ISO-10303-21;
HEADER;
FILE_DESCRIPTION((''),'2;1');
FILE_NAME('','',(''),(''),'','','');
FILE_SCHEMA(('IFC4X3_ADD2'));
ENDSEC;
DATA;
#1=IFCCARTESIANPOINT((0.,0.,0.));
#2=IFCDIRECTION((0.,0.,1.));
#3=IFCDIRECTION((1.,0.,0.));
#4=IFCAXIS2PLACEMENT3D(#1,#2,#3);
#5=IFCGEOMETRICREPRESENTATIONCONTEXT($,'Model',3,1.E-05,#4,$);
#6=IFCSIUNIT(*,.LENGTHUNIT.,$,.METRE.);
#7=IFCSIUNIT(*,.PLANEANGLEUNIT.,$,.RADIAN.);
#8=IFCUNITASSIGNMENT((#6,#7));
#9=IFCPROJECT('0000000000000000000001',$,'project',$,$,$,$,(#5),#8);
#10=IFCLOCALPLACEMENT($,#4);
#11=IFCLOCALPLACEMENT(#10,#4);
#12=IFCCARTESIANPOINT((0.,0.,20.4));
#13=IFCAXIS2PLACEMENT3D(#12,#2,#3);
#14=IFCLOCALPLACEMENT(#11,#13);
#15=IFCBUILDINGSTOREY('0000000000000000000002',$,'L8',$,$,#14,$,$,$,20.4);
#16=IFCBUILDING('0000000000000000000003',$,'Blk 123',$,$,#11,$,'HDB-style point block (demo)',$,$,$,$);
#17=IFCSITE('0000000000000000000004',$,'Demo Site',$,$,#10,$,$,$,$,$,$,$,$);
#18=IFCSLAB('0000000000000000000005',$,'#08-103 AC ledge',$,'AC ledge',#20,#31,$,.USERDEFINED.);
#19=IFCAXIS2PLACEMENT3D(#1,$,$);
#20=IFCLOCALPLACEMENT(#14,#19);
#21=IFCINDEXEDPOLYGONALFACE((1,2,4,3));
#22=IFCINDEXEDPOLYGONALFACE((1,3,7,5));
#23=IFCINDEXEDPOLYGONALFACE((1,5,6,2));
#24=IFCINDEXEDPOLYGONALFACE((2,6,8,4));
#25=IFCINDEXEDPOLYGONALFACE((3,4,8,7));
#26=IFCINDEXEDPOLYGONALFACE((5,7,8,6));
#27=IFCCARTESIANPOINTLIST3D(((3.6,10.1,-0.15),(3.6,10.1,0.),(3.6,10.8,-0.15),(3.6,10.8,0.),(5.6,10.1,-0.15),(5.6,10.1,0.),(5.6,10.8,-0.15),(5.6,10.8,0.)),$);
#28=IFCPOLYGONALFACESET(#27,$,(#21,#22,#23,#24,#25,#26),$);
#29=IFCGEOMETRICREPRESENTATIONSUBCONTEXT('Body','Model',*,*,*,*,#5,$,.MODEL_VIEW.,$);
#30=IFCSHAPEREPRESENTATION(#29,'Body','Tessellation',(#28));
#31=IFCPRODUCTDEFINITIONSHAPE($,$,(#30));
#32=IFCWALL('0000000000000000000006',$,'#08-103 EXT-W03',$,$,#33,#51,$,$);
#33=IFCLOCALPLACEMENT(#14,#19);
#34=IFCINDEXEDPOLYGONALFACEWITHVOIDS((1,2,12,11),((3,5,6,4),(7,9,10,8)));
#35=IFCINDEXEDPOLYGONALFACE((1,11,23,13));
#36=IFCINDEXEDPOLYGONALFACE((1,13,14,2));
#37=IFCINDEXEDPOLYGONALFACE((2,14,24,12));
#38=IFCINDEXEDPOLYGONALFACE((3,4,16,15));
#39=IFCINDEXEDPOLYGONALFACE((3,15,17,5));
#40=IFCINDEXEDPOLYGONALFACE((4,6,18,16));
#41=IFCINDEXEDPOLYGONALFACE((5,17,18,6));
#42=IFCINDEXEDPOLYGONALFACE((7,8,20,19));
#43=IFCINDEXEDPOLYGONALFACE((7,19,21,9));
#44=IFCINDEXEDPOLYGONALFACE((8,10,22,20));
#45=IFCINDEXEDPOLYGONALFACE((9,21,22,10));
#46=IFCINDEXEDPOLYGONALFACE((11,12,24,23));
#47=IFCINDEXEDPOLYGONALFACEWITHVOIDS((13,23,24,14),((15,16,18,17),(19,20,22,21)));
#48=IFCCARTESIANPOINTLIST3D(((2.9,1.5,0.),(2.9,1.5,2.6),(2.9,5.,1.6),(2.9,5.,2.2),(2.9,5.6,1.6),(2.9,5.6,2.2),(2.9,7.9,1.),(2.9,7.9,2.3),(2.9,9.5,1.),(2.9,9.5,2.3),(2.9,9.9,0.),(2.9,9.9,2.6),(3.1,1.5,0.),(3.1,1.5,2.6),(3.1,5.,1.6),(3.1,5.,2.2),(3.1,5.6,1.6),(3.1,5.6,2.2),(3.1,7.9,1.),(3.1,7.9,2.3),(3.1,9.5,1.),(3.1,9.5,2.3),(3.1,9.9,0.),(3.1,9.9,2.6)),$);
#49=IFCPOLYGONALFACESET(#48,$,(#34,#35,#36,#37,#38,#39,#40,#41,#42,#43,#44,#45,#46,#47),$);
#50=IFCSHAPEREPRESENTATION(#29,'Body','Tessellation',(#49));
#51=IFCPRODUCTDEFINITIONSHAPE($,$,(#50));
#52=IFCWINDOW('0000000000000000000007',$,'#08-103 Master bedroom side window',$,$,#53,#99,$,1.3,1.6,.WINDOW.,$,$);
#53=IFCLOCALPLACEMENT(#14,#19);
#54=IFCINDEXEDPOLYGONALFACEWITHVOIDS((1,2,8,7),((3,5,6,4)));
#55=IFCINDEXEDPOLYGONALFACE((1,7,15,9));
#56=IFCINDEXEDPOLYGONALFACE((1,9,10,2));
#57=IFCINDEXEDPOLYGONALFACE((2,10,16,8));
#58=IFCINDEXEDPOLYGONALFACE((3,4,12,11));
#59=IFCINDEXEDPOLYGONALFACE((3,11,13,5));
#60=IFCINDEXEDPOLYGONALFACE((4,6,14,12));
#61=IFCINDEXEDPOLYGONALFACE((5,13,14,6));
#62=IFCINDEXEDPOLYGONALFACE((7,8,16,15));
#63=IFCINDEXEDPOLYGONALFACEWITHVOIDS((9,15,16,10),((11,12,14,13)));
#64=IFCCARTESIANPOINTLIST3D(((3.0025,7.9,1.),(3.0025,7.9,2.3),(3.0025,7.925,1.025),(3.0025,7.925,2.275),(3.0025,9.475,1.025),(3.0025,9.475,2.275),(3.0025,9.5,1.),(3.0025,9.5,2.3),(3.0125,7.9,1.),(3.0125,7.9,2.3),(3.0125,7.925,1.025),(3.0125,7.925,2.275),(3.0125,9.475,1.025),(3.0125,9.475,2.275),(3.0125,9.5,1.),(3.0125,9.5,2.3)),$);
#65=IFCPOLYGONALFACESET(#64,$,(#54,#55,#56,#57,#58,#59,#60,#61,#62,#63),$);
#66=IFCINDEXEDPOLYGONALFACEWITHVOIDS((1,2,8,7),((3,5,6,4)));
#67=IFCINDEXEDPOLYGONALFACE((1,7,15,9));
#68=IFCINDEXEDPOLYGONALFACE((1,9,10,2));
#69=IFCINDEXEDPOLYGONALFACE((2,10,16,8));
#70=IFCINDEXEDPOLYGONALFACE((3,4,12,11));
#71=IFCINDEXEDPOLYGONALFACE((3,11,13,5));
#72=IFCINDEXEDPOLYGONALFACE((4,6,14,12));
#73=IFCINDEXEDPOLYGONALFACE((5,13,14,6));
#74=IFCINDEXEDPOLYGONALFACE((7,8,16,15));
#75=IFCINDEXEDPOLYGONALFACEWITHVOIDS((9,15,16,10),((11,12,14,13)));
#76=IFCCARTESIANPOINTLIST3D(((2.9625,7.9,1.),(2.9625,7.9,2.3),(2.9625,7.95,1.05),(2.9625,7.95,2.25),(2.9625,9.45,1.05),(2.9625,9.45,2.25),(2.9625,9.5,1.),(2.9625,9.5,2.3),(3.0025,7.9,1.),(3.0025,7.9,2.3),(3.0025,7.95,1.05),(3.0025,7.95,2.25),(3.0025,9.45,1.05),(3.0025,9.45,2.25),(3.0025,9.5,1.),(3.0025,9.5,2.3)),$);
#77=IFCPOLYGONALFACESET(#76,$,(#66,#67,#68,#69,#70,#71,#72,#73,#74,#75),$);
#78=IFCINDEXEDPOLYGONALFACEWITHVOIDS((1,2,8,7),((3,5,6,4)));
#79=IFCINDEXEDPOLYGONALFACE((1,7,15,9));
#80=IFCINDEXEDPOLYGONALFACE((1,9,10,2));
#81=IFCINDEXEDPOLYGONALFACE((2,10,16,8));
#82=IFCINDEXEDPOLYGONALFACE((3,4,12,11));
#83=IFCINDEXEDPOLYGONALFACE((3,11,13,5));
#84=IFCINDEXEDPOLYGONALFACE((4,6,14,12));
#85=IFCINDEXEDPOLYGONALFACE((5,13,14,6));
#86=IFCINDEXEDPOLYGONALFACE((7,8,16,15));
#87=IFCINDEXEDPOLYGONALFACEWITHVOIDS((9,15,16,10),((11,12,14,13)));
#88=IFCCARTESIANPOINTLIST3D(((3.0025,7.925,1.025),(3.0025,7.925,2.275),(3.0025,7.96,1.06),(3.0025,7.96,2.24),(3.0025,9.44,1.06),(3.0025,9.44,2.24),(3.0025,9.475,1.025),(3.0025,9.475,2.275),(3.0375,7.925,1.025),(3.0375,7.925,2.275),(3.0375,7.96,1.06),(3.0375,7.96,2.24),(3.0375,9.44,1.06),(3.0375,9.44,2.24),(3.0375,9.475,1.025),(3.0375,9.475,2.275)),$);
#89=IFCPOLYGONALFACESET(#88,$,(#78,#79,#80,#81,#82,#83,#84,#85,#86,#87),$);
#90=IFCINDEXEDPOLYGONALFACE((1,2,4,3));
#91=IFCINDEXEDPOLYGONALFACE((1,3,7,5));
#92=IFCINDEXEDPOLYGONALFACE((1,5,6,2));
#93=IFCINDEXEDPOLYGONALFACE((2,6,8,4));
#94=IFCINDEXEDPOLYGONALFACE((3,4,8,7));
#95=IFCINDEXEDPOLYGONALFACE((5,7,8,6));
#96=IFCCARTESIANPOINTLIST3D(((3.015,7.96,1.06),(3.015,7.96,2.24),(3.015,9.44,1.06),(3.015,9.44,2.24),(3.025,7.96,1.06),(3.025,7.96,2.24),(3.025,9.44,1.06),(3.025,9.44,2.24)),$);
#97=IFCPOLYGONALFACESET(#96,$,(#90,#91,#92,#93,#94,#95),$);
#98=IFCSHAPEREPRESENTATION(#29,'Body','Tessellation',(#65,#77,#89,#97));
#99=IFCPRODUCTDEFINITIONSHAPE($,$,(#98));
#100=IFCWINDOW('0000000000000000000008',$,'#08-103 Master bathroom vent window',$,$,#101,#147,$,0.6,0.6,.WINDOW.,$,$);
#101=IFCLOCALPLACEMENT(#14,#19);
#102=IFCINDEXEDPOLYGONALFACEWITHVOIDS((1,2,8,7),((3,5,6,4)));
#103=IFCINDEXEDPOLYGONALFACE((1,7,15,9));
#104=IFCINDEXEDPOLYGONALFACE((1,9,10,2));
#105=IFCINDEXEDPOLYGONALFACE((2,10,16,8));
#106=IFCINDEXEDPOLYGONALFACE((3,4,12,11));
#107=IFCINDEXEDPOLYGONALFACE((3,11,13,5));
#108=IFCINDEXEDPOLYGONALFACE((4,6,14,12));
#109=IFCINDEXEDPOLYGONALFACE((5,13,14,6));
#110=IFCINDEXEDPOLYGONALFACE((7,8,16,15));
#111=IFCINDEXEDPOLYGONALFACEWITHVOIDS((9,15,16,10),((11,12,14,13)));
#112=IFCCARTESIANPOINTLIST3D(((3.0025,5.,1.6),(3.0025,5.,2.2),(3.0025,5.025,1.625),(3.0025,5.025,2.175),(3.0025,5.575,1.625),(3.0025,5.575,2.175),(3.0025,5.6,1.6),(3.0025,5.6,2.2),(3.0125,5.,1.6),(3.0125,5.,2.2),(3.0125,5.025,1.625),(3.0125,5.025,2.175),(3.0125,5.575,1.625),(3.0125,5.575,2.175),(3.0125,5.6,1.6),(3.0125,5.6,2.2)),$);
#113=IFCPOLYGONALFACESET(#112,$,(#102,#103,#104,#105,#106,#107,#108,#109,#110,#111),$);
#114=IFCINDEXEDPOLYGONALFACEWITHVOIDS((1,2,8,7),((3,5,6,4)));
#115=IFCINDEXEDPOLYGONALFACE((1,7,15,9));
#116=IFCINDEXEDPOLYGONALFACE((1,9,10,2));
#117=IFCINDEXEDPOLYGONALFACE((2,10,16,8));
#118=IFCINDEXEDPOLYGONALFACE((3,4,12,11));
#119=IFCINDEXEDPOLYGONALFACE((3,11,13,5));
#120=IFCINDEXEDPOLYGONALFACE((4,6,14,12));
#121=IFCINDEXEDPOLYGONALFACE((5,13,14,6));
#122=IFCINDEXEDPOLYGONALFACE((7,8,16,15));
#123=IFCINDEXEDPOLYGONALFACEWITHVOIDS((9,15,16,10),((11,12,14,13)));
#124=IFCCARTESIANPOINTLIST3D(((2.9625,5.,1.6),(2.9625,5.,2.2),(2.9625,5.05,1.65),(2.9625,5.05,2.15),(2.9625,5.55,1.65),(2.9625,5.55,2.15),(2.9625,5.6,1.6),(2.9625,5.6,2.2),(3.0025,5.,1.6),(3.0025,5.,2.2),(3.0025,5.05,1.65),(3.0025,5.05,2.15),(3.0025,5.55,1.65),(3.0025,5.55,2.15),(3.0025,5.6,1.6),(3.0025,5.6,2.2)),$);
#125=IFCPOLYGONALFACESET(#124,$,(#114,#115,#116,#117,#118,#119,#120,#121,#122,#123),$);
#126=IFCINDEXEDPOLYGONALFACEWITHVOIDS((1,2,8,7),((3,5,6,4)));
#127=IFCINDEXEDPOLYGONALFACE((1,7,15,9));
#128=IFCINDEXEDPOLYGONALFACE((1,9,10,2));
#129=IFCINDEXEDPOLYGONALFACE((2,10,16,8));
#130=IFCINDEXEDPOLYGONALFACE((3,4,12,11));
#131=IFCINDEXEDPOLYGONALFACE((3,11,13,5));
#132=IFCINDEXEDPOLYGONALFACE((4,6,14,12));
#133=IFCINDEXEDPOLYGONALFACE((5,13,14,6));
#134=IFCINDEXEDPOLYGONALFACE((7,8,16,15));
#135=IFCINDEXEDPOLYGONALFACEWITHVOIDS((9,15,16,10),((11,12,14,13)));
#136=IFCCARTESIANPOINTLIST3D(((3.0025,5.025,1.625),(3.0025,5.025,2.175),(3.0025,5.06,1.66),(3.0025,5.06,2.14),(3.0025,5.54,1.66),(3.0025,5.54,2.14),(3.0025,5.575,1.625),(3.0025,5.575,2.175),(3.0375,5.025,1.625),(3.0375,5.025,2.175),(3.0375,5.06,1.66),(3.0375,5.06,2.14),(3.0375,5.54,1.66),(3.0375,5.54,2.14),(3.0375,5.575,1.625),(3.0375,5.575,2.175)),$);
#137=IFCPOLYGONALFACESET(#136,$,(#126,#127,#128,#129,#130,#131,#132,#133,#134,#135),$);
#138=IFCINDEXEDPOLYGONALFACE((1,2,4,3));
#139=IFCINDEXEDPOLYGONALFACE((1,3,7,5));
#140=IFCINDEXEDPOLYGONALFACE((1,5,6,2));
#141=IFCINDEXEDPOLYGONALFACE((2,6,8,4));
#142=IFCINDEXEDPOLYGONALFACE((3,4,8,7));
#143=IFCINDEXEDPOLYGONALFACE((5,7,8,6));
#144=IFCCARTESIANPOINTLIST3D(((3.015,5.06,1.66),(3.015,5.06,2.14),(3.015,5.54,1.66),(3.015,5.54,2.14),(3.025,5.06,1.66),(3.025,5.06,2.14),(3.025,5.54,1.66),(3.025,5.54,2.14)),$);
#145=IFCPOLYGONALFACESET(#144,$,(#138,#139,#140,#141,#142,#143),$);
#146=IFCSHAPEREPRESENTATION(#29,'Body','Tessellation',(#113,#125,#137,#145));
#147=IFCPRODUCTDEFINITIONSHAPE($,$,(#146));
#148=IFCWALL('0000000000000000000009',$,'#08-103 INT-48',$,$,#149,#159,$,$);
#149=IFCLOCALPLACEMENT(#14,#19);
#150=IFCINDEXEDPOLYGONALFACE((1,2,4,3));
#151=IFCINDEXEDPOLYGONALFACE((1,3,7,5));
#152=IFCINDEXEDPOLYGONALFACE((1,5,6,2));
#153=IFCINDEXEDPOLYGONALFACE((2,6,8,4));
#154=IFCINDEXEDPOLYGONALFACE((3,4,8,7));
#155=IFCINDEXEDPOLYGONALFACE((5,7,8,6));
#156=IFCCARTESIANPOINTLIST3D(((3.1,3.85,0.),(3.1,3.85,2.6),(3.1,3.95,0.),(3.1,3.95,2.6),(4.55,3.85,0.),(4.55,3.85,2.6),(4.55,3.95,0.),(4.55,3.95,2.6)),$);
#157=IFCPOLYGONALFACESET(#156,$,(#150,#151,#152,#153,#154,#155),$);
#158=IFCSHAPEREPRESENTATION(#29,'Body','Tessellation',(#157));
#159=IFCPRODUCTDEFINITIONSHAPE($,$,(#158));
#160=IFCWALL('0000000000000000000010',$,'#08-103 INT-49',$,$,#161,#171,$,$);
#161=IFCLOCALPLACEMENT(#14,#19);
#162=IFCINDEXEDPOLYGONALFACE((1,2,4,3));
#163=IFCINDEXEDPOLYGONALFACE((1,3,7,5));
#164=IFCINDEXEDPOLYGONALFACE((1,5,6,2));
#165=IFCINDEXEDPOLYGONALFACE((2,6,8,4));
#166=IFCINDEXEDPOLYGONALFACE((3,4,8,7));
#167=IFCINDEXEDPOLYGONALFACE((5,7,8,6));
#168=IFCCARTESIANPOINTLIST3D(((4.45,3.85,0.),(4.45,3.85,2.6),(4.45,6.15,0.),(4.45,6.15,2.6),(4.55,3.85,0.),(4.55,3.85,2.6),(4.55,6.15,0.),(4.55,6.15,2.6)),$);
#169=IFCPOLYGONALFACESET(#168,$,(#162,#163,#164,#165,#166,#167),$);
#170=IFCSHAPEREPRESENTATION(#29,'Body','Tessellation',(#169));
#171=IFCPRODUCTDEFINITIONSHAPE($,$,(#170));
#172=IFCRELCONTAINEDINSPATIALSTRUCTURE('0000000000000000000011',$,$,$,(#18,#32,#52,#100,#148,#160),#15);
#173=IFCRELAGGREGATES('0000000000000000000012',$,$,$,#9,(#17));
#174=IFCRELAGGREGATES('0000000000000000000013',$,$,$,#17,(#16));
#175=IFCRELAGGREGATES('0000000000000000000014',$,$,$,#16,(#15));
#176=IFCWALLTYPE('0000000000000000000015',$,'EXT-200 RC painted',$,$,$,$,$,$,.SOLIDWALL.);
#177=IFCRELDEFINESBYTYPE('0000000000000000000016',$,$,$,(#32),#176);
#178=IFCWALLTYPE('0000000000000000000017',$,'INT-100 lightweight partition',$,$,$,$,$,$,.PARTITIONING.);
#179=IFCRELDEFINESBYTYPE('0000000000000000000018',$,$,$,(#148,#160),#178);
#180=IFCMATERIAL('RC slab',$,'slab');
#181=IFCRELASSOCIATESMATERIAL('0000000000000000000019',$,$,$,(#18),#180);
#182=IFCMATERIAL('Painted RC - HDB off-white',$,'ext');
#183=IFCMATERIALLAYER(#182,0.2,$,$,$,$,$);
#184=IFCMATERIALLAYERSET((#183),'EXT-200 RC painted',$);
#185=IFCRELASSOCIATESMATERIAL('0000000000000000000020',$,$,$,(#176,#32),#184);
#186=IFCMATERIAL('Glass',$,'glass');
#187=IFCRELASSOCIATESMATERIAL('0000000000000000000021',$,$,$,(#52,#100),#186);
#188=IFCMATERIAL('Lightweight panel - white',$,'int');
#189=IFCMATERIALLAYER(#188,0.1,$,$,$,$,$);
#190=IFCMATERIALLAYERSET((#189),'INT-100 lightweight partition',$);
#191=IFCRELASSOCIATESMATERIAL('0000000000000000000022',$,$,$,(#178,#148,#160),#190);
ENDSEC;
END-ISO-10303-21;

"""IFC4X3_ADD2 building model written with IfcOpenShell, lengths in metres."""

from ifc_helpers import new_model, si_unit, frame, origin, origin_with_axes, place, context, subcontext, project, spatial, polyline, line, indexed_curve, outline, extrude, material, layer, layer_set, layer_usage, type_object, element, fill, save


model = new_model("IFC4X3_ADD2")

# Units and contexts
model_context = context("Model", 3, precision=1e-05, world=origin_with_axes())
body_context = subcontext(model_context, "Body", "Model", "MODEL_VIEW")
ifc_project = project(units=[si_unit("LENGTHUNIT", "METRE"), si_unit("PLANEANGLEUNIT", "RADIAN")], contexts=[model_context])

# Site, building, storey
site_placement = place(None, origin_with_axes())
site = spatial("IfcSite", under=ifc_project, at=site_placement, Name="Demo Site")
building_placement = place(site_placement, origin_with_axes())
building = spatial("IfcBuilding", under=site, at=building_placement, Name="Blk 123", LongName="HDB-style point block (demo)")
storey_placement = place(building_placement, frame((0.0, 0.0, 20.4), z_axis=(0.0, 0.0, 1.0), x_axis=(1.0, 0.0, 0.0)))
storey = spatial("IfcBuildingStorey", under=building, at=storey_placement, Name="L8", Elevation=20.4)

# Slab
ifc_material_1 = material(Name="RC slab", Category="slab")
slab_placement = place(storey_placement, frame((4.6, 10.45, -0.15), z_axis=(0.0, 0.0, 1.0), x_axis=(1.0, 0.0, 0.0)))
element("IfcSlab", 1, at=slab_placement, inside=storey, material=ifc_material_1, Name="#08-103 AC ledge", ObjectType="AC ledge", PredefinedType="USERDEFINED", context=body_context, shape_type="SweptSolid", body=[
    extrude(outline(polyline([(1.0, -0.35), (1.0, 0.35), (-1.0, 0.35), (-1.0, -0.35), (1.0, -0.35)])), origin(), (0.0, 0.0, 1.0), 0.15),
])

# Wall, openings, windows
ifc_material_2 = material(Name="Painted RC - HDB off-white", Category="ext")
ifc_layer_1 = layer(ifc_material_2, 0.2)
ifc_layer_set_1 = layer_set([ifc_layer_1], Name="EXT-200 RC painted")
ifc_layer_usage_1 = layer_usage(ifc_layer_set_1, "AXIS2", "POSITIVE", 0.0)
wall_type_1 = type_object("IfcWallType", Name="EXT-200 RC painted", PredefinedType="SOLIDWALL", material=ifc_layer_set_1)
wall_1_placement = place(storey_placement, frame((2.9, 9.9, 0.0), z_axis=(0.0, 0.0, 1.0), x_axis=(0.0, -1.0, 0.0)))
wall_1 = element("IfcWall", 2, at=wall_1_placement, inside=storey, type_object=wall_type_1, material=ifc_layer_usage_1, Name="#08-103 EXT-W03", context=body_context, shape_type="SweptSolid", body=[
    extrude(outline(indexed_curve([(0.0, 0.0), (0.0, 0.2), (8.4, 0.2), (8.4, 0.0), (0.0, 0.0)], self_intersect=False)), origin_with_axes(), (0.0, 0.0, 1.0), 2.6),
])
opening_1_placement = place(wall_1_placement, frame((0.4, -0.1, 1.0), z_axis=(0.0, 0.0, 1.0), x_axis=(1.0, 0.0, 0.0)))
opening_1 = element("IfcOpeningElement", 3, at=opening_1_placement, cuts=wall_1, context=body_context, shape_type="SweptSolid", body=[
    extrude(outline(indexed_curve([(0.0, 0.0), (0.0, 0.4), (1.6, 0.4), (1.6, 0.0), (0.0, 0.0)], self_intersect=False)), origin_with_axes(), (0.0, 0.0, 1.0), 1.3),
])
opening_2_placement = place(wall_1_placement, frame((4.3, -0.1, 1.6), z_axis=(0.0, 0.0, 1.0), x_axis=(1.0, 0.0, 0.0)))
opening_2 = element("IfcOpeningElement", 4, at=opening_2_placement, cuts=wall_1, context=body_context, shape_type="SweptSolid", body=[
    extrude(outline(indexed_curve([(0.0, 0.0), (0.0, 0.4), (0.6, 0.4), (0.6, 0.0), (0.0, 0.0)], self_intersect=False)), origin_with_axes(), (0.0, 0.0, 1.0), 0.6),
])
ifc_material_3 = material(Name="Glass", Category="glass")
window_1_placement = place(opening_1_placement, frame((0.0, 0.1125, 0.0), z_axis=(0.0, 0.0, 1.0), x_axis=(1.0, 0.0, 0.0)))
window_1 = element("IfcWindow", 5, at=window_1_placement, inside=storey, material=ifc_material_3, Name="#08-103 Master bedroom side window", OverallHeight=1.3, OverallWidth=1.6, PredefinedType="WINDOW", context=body_context, shape_type="SweptSolid", body=[
    extrude(outline(indexed_curve([(0.0, 0.0), (1.6, 0.0), (1.6, 1.3), (0.0, 1.3)], segments=[line(1, 2, 3, 4, 1)]), holes=[indexed_curve([(0.025, 0.025), (1.575, 0.025), (1.575, 1.275), (0.025, 1.275)], segments=[line(1, 2, 3, 4, 1)])]), frame((0.0, 0.09, 0.0), z_axis=(0.0, -1.0, 0.0), x_axis=(1.0, 0.0, 0.0)), (0.0, 0.0, -1.0), 0.01),
    extrude(outline(indexed_curve([(0.0, 0.0), (1.6, 0.0), (1.6, 1.3), (0.0, 1.3)], segments=[line(1, 2, 3, 4, 1)]), holes=[indexed_curve([(0.05, 0.05), (1.55, 0.05), (1.55, 1.25), (0.05, 1.25)], segments=[line(1, 2, 3, 4, 1)])]), frame((0.0, 0.05, 0.0), z_axis=(0.0, -1.0, 0.0), x_axis=(1.0, 0.0, 0.0)), (0.0, 0.0, -1.0), 0.04),
    extrude(outline(indexed_curve([(0.0, 0.0), (1.55, 0.0), (1.55, 1.25), (0.0, 1.25)], segments=[line(1, 2, 3, 4, 1)]), holes=[indexed_curve([(0.035, 0.035), (1.515, 0.035), (1.515, 1.215), (0.035, 1.215)], segments=[line(1, 2, 3, 4, 1)])]), frame((0.025, 0.09, 0.025), z_axis=(0.0, -1.0, 0.0), x_axis=(1.0, 0.0, 0.0)), (0.0, 0.0, -1.0), 0.035),
    extrude(outline(indexed_curve([(0.035, 0.035), (1.515, 0.035), (1.515, 1.215), (0.035, 1.215)], segments=[line(1, 2, 3, 4, 1)])), frame((0.025, 0.1025, 0.025), z_axis=(0.0, -1.0, 0.0), x_axis=(1.0, 0.0, 0.0)), (0.0, 0.0, -1.0), 0.01),
])
fill(opening_1, window_1)
window_2_placement = place(opening_2_placement, frame((0.0, 0.1125, 0.0), z_axis=(0.0, 0.0, 1.0), x_axis=(1.0, 0.0, 0.0)))
window_2 = element("IfcWindow", 6, at=window_2_placement, inside=storey, material=ifc_material_3, Name="#08-103 Master bathroom vent window", OverallHeight=0.6, OverallWidth=0.6, PredefinedType="WINDOW", context=body_context, shape_type="SweptSolid", body=[
    extrude(outline(indexed_curve([(0.0, 0.0), (0.6, 0.0), (0.6, 0.6), (0.0, 0.6)], segments=[line(1, 2, 3, 4, 1)]), holes=[indexed_curve([(0.025, 0.025), (0.575, 0.025), (0.575, 0.575), (0.025, 0.575)], segments=[line(1, 2, 3, 4, 1)])]), frame((0.0, 0.09, 0.0), z_axis=(0.0, -1.0, 0.0), x_axis=(1.0, 0.0, 0.0)), (0.0, 0.0, -1.0), 0.01),
    extrude(outline(indexed_curve([(0.0, 0.0), (0.6, 0.0), (0.6, 0.6), (0.0, 0.6)], segments=[line(1, 2, 3, 4, 1)]), holes=[indexed_curve([(0.05, 0.05), (0.55, 0.05), (0.55, 0.55), (0.05, 0.55)], segments=[line(1, 2, 3, 4, 1)])]), frame((0.0, 0.05, 0.0), z_axis=(0.0, -1.0, 0.0), x_axis=(1.0, 0.0, 0.0)), (0.0, 0.0, -1.0), 0.04),
    extrude(outline(indexed_curve([(0.0, 0.0), (0.55, 0.0), (0.55, 0.55), (0.0, 0.55)], segments=[line(1, 2, 3, 4, 1)]), holes=[indexed_curve([(0.035, 0.035), (0.515, 0.035), (0.515, 0.515), (0.035, 0.515)], segments=[line(1, 2, 3, 4, 1)])]), frame((0.025, 0.09, 0.025), z_axis=(0.0, -1.0, 0.0), x_axis=(1.0, 0.0, 0.0)), (0.0, 0.0, -1.0), 0.035),
    extrude(outline(indexed_curve([(0.035, 0.035), (0.515, 0.035), (0.515, 0.515), (0.035, 0.515)], segments=[line(1, 2, 3, 4, 1)])), frame((0.025, 0.1025, 0.025), z_axis=(0.0, -1.0, 0.0), x_axis=(1.0, 0.0, 0.0)), (0.0, 0.0, -1.0), 0.01),
])
fill(opening_2, window_2)

# Shared definitions
ifc_material_4 = material(Name="Lightweight panel - white", Category="int")
ifc_layer_2 = layer(ifc_material_4, 0.1)
ifc_layer_set_2 = layer_set([ifc_layer_2], Name="INT-100 lightweight partition")
ifc_layer_usage_2 = layer_usage(ifc_layer_set_2, "AXIS2", "POSITIVE", -0.05)
wall_type_2 = type_object("IfcWallType", Name="INT-100 lightweight partition", PredefinedType="PARTITIONING", material=ifc_layer_set_2)

# Walls
wall_2_placement = place(storey_placement, frame((3.1, 3.9, 0.0), z_axis=(0.0, 0.0, 1.0), x_axis=(1.0, 0.0, 0.0)))
element("IfcWall", 7, at=wall_2_placement, inside=storey, type_object=wall_type_2, material=ifc_layer_usage_2, Name="#08-103 INT-48", context=body_context, shape_type="SweptSolid", body=[
    extrude(outline(indexed_curve([(0.0, 0.0), (0.0, 0.1), (1.45, 0.1), (1.45, 0.0), (0.0, 0.0)], self_intersect=False)), frame((0.0, -0.05, 0.0), z_axis=(0.0, 0.0, 1.0), x_axis=(1.0, 0.0, 0.0)), (0.0, 0.0, 1.0), 2.6),
])
wall_3_placement = place(storey_placement, frame((4.5, 3.85, 0.0), z_axis=(0.0, 0.0, 1.0), x_axis=(0.0, 1.0, 0.0)))
element("IfcWall", 8, at=wall_3_placement, inside=storey, type_object=wall_type_2, material=ifc_layer_usage_2, Name="#08-103 INT-49", context=body_context, shape_type="SweptSolid", body=[
    extrude(outline(indexed_curve([(0.0, 0.0), (0.0, 0.1), (2.3, 0.1), (2.3, 0.0), (0.0, 0.0)], self_intersect=False)), frame((0.0, -0.05, 0.0), z_axis=(0.0, 0.0, 1.0), x_axis=(1.0, 0.0, 0.0)), (0.0, 0.0, 1.0), 2.6),
])

save(model, "model.ifc")
